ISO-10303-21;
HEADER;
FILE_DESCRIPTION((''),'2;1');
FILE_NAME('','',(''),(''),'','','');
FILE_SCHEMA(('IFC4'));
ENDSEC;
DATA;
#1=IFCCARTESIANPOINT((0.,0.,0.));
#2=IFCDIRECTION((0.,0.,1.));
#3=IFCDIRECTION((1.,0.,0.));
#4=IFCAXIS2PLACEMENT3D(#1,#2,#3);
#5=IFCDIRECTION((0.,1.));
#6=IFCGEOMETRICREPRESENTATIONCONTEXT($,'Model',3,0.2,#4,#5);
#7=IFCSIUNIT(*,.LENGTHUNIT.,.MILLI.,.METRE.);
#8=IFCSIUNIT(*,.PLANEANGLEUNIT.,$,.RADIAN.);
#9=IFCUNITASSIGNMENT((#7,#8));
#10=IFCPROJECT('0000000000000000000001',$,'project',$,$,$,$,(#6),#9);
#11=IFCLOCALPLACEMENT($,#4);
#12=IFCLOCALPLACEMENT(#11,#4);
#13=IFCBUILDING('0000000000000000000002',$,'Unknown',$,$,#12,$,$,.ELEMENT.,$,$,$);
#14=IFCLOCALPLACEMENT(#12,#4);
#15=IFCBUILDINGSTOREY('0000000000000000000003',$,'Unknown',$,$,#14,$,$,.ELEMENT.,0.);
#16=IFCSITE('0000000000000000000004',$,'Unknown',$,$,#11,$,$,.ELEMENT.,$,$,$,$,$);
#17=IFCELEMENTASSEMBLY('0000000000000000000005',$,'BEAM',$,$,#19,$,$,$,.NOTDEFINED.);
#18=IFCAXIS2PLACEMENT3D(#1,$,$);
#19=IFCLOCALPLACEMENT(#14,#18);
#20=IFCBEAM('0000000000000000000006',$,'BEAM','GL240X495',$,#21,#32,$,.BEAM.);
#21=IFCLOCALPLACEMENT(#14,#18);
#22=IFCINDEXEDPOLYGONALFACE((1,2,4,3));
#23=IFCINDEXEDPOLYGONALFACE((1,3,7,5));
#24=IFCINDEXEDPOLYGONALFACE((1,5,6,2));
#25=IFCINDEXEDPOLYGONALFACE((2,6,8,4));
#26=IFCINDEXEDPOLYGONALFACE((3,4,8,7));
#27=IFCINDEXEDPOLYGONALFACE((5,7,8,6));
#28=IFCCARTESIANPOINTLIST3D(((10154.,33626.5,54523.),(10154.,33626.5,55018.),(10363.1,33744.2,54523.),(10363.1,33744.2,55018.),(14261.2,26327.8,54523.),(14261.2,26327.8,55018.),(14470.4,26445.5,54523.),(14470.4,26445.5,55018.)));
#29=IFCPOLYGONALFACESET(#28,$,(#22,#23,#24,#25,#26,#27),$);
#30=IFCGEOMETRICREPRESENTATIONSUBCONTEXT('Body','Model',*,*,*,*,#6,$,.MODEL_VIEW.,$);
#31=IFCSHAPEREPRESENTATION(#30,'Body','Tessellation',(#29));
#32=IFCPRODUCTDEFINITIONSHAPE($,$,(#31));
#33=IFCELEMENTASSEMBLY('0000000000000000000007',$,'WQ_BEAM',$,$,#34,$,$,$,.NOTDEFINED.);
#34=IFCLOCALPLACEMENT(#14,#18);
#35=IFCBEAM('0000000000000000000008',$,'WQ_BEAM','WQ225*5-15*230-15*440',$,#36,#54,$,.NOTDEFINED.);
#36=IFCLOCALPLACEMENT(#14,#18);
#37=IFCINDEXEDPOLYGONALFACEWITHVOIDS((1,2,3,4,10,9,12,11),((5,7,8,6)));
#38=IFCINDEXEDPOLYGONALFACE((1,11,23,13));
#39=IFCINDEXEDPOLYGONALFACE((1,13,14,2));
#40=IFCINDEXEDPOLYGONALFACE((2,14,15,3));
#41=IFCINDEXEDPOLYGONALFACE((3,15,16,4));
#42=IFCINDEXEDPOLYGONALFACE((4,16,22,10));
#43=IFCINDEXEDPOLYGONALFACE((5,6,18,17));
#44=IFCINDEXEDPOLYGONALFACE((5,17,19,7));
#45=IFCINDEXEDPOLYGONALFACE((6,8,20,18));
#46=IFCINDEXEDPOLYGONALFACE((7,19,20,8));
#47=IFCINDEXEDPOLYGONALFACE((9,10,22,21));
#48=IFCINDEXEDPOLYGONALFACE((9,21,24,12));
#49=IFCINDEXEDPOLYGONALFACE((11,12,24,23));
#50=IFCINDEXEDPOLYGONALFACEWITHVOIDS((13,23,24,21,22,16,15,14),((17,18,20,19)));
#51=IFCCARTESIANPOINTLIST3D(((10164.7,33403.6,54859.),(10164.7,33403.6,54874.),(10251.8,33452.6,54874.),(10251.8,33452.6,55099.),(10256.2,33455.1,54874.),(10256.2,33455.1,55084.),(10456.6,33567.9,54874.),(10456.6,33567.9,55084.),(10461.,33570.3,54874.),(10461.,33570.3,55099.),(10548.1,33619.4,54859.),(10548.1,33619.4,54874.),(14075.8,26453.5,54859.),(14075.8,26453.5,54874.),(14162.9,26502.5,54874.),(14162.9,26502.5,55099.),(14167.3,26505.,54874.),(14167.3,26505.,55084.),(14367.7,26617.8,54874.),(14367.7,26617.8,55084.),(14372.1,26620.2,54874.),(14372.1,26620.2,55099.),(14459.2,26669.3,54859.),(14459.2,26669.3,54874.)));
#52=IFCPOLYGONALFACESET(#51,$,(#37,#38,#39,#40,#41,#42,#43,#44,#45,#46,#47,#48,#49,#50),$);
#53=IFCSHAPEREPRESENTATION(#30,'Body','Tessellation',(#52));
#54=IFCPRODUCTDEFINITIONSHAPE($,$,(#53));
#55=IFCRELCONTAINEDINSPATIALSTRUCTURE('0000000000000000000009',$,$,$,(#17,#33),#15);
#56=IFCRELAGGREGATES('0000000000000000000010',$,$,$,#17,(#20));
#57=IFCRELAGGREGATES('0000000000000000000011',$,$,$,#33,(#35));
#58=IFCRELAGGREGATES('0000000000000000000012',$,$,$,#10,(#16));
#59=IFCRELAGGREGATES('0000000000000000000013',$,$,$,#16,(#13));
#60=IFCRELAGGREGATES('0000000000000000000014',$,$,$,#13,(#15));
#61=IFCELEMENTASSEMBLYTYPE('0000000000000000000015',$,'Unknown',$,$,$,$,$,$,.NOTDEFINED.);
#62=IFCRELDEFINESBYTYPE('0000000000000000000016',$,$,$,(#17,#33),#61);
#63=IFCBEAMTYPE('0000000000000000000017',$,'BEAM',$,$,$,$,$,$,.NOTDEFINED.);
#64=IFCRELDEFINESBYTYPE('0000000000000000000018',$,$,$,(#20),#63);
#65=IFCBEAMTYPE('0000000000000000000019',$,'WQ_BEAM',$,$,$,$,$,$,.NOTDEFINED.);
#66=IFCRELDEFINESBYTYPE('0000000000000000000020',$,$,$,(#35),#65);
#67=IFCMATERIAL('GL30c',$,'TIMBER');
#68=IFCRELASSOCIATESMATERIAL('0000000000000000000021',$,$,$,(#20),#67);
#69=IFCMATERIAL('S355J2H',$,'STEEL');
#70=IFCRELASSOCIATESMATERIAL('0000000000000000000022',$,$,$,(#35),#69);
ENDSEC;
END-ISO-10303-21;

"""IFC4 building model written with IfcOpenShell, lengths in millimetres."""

from ifc_helpers import new_model, si_unit, direction, frame, origin_with_axes, place, context, subcontext, project, spatial, polyline, outline, extrude, material, material_profile, profile_set, profile_usage, type_object, element, aggregate, save


model = new_model("IFC4")

# Units and contexts
model_context = context("Model", 3, precision=0.2, world=origin_with_axes(), true_north=direction((0.0, 1.0)))
body_context = subcontext(model_context, "Body", "Model", "MODEL_VIEW")
ifc_project = project(units=[si_unit("LENGTHUNIT", "METRE", prefix="MILLI"), si_unit("PLANEANGLEUNIT", "RADIAN")], contexts=[model_context])

# Site, building, storey
site_placement = place(None, origin_with_axes())
site = spatial("IfcSite", under=ifc_project, at=site_placement, Name="Unknown", CompositionType="ELEMENT")
building_placement = place(site_placement, origin_with_axes())
building = spatial("IfcBuilding", under=site, at=building_placement, Name="Unknown", CompositionType="ELEMENT")
storey_placement = place(building_placement, origin_with_axes())
storey = spatial("IfcBuildingStorey", under=building, at=storey_placement, Name="Unknown", CompositionType="ELEMENT", Elevation=0.0)

# Shared definitions
element_assembly_type = type_object("IfcElementAssemblyType", Name="Unknown", PredefinedType="NOTDEFINED")

# Element assemblies, beams
assembly_1_placement = place(storey_placement, frame((10258.6, 33685.3, 54770.5), z_axis=(-0.871487, -0.490418, 0.0), x_axis=(0.490421, -0.871485, 0.0)))
assembly_1 = element("IfcElementAssembly", 1, at=assembly_1_placement, inside=storey, type_object=element_assembly_type, Name="BEAM", PredefinedType="NOTDEFINED")
ifc_material_1 = material(Name="GL30c", Category="TIMBER")
ifc_material_profile_1 = material_profile(ifc_material_1, outline(polyline([(-120.0, 247.5), (-120.0, -247.5), (120.0, -247.5), (120.0, 247.5), (-120.0, 247.5)])), Name="GL240X495")
ifc_profile_set_1 = profile_set([ifc_material_profile_1])
ifc_profile_usage_1 = profile_usage(ifc_profile_set_1, cardinal=8)
beam_type_1 = type_object("IfcBeamType", Name="BEAM")
beam_1_placement = place(assembly_1_placement, origin_with_axes())
beam_1 = element("IfcBeam", 2, at=beam_1_placement, type_object=beam_type_1, material=ifc_profile_usage_1, Name="BEAM", Description="GL240X495", PredefinedType="BEAM", context=body_context, shape_type="SolidModel", body=[
    extrude(outline(polyline([(-120.0, 247.5), (-120.0, -247.5), (120.0, -247.5), (120.0, 247.5), (-120.0, 247.5)])), frame((0.0, 0.0, 0.0), z_axis=(-1.0, 0.0, 0.0), x_axis=(0.0, 0.0, 1.0)), (0.0, 0.0, -1.0), 8375.0),
])
aggregate(assembly_1, [beam_1])
assembly_2_placement = place(storey_placement, frame((10356.4, 33511.5, 54979.0), z_axis=(-0.871487, -0.490418, 0.0), x_axis=(0.490421, -0.871485, 0.0)))
assembly_2 = element("IfcElementAssembly", 3, at=assembly_2_placement, inside=storey, type_object=element_assembly_type, Name="WQ_BEAM", PredefinedType="NOTDEFINED")
ifc_material_2 = material(Name="S355J2H", Category="STEEL")
ifc_material_profile_2 = material_profile(ifc_material_2, outline(polyline([(-220.0, -120.0), (220.0, -120.0), (220.0, -105.0), (120.0, -105.0), (120.0, 120.0), (-120.0, 120.0), (-120.0, -105.0), (-220.0, -105.0), (-220.0, -120.0)]), holes=[polyline([(-115.0, -105.0), (-115.0, 105.0), (115.0, 105.0), (115.0, -105.0), (-115.0, -105.0)])]), Name="WQ225*5-15*230-15*440")
ifc_profile_set_2 = profile_set([ifc_material_profile_2])
ifc_profile_usage_2 = profile_usage(ifc_profile_set_2, cardinal=8)
beam_type_2 = type_object("IfcBeamType", Name="WQ_BEAM")
beam_2_placement = place(assembly_2_placement, origin_with_axes())
beam_2 = element("IfcBeam", 4, at=beam_2_placement, type_object=beam_type_2, material=ifc_profile_usage_2, Name="WQ_BEAM", Description="WQ225*5-15*230-15*440", PredefinedType="NOTDEFINED", context=body_context, shape_type="SolidModel", body=[
    extrude(outline(polyline([(-220.0, -120.0), (220.0, -120.0), (220.0, -105.0), (120.0, -105.0), (120.0, 120.0), (-120.0, 120.0), (-120.0, -105.0), (-220.0, -105.0), (-220.0, -120.0)]), holes=[polyline([(-115.0, -105.0), (-115.0, 105.0), (115.0, 105.0), (115.0, -105.0), (-115.0, -105.0)])]), frame((0.0, 0.0, 0.0), z_axis=(-1.0, 0.0, 0.0), x_axis=(0.0, 0.0, 1.0)), (0.0, 0.0, -1.0), 7975.0),
])
aggregate(assembly_2, [beam_2])

save(model, "model.ifc")
